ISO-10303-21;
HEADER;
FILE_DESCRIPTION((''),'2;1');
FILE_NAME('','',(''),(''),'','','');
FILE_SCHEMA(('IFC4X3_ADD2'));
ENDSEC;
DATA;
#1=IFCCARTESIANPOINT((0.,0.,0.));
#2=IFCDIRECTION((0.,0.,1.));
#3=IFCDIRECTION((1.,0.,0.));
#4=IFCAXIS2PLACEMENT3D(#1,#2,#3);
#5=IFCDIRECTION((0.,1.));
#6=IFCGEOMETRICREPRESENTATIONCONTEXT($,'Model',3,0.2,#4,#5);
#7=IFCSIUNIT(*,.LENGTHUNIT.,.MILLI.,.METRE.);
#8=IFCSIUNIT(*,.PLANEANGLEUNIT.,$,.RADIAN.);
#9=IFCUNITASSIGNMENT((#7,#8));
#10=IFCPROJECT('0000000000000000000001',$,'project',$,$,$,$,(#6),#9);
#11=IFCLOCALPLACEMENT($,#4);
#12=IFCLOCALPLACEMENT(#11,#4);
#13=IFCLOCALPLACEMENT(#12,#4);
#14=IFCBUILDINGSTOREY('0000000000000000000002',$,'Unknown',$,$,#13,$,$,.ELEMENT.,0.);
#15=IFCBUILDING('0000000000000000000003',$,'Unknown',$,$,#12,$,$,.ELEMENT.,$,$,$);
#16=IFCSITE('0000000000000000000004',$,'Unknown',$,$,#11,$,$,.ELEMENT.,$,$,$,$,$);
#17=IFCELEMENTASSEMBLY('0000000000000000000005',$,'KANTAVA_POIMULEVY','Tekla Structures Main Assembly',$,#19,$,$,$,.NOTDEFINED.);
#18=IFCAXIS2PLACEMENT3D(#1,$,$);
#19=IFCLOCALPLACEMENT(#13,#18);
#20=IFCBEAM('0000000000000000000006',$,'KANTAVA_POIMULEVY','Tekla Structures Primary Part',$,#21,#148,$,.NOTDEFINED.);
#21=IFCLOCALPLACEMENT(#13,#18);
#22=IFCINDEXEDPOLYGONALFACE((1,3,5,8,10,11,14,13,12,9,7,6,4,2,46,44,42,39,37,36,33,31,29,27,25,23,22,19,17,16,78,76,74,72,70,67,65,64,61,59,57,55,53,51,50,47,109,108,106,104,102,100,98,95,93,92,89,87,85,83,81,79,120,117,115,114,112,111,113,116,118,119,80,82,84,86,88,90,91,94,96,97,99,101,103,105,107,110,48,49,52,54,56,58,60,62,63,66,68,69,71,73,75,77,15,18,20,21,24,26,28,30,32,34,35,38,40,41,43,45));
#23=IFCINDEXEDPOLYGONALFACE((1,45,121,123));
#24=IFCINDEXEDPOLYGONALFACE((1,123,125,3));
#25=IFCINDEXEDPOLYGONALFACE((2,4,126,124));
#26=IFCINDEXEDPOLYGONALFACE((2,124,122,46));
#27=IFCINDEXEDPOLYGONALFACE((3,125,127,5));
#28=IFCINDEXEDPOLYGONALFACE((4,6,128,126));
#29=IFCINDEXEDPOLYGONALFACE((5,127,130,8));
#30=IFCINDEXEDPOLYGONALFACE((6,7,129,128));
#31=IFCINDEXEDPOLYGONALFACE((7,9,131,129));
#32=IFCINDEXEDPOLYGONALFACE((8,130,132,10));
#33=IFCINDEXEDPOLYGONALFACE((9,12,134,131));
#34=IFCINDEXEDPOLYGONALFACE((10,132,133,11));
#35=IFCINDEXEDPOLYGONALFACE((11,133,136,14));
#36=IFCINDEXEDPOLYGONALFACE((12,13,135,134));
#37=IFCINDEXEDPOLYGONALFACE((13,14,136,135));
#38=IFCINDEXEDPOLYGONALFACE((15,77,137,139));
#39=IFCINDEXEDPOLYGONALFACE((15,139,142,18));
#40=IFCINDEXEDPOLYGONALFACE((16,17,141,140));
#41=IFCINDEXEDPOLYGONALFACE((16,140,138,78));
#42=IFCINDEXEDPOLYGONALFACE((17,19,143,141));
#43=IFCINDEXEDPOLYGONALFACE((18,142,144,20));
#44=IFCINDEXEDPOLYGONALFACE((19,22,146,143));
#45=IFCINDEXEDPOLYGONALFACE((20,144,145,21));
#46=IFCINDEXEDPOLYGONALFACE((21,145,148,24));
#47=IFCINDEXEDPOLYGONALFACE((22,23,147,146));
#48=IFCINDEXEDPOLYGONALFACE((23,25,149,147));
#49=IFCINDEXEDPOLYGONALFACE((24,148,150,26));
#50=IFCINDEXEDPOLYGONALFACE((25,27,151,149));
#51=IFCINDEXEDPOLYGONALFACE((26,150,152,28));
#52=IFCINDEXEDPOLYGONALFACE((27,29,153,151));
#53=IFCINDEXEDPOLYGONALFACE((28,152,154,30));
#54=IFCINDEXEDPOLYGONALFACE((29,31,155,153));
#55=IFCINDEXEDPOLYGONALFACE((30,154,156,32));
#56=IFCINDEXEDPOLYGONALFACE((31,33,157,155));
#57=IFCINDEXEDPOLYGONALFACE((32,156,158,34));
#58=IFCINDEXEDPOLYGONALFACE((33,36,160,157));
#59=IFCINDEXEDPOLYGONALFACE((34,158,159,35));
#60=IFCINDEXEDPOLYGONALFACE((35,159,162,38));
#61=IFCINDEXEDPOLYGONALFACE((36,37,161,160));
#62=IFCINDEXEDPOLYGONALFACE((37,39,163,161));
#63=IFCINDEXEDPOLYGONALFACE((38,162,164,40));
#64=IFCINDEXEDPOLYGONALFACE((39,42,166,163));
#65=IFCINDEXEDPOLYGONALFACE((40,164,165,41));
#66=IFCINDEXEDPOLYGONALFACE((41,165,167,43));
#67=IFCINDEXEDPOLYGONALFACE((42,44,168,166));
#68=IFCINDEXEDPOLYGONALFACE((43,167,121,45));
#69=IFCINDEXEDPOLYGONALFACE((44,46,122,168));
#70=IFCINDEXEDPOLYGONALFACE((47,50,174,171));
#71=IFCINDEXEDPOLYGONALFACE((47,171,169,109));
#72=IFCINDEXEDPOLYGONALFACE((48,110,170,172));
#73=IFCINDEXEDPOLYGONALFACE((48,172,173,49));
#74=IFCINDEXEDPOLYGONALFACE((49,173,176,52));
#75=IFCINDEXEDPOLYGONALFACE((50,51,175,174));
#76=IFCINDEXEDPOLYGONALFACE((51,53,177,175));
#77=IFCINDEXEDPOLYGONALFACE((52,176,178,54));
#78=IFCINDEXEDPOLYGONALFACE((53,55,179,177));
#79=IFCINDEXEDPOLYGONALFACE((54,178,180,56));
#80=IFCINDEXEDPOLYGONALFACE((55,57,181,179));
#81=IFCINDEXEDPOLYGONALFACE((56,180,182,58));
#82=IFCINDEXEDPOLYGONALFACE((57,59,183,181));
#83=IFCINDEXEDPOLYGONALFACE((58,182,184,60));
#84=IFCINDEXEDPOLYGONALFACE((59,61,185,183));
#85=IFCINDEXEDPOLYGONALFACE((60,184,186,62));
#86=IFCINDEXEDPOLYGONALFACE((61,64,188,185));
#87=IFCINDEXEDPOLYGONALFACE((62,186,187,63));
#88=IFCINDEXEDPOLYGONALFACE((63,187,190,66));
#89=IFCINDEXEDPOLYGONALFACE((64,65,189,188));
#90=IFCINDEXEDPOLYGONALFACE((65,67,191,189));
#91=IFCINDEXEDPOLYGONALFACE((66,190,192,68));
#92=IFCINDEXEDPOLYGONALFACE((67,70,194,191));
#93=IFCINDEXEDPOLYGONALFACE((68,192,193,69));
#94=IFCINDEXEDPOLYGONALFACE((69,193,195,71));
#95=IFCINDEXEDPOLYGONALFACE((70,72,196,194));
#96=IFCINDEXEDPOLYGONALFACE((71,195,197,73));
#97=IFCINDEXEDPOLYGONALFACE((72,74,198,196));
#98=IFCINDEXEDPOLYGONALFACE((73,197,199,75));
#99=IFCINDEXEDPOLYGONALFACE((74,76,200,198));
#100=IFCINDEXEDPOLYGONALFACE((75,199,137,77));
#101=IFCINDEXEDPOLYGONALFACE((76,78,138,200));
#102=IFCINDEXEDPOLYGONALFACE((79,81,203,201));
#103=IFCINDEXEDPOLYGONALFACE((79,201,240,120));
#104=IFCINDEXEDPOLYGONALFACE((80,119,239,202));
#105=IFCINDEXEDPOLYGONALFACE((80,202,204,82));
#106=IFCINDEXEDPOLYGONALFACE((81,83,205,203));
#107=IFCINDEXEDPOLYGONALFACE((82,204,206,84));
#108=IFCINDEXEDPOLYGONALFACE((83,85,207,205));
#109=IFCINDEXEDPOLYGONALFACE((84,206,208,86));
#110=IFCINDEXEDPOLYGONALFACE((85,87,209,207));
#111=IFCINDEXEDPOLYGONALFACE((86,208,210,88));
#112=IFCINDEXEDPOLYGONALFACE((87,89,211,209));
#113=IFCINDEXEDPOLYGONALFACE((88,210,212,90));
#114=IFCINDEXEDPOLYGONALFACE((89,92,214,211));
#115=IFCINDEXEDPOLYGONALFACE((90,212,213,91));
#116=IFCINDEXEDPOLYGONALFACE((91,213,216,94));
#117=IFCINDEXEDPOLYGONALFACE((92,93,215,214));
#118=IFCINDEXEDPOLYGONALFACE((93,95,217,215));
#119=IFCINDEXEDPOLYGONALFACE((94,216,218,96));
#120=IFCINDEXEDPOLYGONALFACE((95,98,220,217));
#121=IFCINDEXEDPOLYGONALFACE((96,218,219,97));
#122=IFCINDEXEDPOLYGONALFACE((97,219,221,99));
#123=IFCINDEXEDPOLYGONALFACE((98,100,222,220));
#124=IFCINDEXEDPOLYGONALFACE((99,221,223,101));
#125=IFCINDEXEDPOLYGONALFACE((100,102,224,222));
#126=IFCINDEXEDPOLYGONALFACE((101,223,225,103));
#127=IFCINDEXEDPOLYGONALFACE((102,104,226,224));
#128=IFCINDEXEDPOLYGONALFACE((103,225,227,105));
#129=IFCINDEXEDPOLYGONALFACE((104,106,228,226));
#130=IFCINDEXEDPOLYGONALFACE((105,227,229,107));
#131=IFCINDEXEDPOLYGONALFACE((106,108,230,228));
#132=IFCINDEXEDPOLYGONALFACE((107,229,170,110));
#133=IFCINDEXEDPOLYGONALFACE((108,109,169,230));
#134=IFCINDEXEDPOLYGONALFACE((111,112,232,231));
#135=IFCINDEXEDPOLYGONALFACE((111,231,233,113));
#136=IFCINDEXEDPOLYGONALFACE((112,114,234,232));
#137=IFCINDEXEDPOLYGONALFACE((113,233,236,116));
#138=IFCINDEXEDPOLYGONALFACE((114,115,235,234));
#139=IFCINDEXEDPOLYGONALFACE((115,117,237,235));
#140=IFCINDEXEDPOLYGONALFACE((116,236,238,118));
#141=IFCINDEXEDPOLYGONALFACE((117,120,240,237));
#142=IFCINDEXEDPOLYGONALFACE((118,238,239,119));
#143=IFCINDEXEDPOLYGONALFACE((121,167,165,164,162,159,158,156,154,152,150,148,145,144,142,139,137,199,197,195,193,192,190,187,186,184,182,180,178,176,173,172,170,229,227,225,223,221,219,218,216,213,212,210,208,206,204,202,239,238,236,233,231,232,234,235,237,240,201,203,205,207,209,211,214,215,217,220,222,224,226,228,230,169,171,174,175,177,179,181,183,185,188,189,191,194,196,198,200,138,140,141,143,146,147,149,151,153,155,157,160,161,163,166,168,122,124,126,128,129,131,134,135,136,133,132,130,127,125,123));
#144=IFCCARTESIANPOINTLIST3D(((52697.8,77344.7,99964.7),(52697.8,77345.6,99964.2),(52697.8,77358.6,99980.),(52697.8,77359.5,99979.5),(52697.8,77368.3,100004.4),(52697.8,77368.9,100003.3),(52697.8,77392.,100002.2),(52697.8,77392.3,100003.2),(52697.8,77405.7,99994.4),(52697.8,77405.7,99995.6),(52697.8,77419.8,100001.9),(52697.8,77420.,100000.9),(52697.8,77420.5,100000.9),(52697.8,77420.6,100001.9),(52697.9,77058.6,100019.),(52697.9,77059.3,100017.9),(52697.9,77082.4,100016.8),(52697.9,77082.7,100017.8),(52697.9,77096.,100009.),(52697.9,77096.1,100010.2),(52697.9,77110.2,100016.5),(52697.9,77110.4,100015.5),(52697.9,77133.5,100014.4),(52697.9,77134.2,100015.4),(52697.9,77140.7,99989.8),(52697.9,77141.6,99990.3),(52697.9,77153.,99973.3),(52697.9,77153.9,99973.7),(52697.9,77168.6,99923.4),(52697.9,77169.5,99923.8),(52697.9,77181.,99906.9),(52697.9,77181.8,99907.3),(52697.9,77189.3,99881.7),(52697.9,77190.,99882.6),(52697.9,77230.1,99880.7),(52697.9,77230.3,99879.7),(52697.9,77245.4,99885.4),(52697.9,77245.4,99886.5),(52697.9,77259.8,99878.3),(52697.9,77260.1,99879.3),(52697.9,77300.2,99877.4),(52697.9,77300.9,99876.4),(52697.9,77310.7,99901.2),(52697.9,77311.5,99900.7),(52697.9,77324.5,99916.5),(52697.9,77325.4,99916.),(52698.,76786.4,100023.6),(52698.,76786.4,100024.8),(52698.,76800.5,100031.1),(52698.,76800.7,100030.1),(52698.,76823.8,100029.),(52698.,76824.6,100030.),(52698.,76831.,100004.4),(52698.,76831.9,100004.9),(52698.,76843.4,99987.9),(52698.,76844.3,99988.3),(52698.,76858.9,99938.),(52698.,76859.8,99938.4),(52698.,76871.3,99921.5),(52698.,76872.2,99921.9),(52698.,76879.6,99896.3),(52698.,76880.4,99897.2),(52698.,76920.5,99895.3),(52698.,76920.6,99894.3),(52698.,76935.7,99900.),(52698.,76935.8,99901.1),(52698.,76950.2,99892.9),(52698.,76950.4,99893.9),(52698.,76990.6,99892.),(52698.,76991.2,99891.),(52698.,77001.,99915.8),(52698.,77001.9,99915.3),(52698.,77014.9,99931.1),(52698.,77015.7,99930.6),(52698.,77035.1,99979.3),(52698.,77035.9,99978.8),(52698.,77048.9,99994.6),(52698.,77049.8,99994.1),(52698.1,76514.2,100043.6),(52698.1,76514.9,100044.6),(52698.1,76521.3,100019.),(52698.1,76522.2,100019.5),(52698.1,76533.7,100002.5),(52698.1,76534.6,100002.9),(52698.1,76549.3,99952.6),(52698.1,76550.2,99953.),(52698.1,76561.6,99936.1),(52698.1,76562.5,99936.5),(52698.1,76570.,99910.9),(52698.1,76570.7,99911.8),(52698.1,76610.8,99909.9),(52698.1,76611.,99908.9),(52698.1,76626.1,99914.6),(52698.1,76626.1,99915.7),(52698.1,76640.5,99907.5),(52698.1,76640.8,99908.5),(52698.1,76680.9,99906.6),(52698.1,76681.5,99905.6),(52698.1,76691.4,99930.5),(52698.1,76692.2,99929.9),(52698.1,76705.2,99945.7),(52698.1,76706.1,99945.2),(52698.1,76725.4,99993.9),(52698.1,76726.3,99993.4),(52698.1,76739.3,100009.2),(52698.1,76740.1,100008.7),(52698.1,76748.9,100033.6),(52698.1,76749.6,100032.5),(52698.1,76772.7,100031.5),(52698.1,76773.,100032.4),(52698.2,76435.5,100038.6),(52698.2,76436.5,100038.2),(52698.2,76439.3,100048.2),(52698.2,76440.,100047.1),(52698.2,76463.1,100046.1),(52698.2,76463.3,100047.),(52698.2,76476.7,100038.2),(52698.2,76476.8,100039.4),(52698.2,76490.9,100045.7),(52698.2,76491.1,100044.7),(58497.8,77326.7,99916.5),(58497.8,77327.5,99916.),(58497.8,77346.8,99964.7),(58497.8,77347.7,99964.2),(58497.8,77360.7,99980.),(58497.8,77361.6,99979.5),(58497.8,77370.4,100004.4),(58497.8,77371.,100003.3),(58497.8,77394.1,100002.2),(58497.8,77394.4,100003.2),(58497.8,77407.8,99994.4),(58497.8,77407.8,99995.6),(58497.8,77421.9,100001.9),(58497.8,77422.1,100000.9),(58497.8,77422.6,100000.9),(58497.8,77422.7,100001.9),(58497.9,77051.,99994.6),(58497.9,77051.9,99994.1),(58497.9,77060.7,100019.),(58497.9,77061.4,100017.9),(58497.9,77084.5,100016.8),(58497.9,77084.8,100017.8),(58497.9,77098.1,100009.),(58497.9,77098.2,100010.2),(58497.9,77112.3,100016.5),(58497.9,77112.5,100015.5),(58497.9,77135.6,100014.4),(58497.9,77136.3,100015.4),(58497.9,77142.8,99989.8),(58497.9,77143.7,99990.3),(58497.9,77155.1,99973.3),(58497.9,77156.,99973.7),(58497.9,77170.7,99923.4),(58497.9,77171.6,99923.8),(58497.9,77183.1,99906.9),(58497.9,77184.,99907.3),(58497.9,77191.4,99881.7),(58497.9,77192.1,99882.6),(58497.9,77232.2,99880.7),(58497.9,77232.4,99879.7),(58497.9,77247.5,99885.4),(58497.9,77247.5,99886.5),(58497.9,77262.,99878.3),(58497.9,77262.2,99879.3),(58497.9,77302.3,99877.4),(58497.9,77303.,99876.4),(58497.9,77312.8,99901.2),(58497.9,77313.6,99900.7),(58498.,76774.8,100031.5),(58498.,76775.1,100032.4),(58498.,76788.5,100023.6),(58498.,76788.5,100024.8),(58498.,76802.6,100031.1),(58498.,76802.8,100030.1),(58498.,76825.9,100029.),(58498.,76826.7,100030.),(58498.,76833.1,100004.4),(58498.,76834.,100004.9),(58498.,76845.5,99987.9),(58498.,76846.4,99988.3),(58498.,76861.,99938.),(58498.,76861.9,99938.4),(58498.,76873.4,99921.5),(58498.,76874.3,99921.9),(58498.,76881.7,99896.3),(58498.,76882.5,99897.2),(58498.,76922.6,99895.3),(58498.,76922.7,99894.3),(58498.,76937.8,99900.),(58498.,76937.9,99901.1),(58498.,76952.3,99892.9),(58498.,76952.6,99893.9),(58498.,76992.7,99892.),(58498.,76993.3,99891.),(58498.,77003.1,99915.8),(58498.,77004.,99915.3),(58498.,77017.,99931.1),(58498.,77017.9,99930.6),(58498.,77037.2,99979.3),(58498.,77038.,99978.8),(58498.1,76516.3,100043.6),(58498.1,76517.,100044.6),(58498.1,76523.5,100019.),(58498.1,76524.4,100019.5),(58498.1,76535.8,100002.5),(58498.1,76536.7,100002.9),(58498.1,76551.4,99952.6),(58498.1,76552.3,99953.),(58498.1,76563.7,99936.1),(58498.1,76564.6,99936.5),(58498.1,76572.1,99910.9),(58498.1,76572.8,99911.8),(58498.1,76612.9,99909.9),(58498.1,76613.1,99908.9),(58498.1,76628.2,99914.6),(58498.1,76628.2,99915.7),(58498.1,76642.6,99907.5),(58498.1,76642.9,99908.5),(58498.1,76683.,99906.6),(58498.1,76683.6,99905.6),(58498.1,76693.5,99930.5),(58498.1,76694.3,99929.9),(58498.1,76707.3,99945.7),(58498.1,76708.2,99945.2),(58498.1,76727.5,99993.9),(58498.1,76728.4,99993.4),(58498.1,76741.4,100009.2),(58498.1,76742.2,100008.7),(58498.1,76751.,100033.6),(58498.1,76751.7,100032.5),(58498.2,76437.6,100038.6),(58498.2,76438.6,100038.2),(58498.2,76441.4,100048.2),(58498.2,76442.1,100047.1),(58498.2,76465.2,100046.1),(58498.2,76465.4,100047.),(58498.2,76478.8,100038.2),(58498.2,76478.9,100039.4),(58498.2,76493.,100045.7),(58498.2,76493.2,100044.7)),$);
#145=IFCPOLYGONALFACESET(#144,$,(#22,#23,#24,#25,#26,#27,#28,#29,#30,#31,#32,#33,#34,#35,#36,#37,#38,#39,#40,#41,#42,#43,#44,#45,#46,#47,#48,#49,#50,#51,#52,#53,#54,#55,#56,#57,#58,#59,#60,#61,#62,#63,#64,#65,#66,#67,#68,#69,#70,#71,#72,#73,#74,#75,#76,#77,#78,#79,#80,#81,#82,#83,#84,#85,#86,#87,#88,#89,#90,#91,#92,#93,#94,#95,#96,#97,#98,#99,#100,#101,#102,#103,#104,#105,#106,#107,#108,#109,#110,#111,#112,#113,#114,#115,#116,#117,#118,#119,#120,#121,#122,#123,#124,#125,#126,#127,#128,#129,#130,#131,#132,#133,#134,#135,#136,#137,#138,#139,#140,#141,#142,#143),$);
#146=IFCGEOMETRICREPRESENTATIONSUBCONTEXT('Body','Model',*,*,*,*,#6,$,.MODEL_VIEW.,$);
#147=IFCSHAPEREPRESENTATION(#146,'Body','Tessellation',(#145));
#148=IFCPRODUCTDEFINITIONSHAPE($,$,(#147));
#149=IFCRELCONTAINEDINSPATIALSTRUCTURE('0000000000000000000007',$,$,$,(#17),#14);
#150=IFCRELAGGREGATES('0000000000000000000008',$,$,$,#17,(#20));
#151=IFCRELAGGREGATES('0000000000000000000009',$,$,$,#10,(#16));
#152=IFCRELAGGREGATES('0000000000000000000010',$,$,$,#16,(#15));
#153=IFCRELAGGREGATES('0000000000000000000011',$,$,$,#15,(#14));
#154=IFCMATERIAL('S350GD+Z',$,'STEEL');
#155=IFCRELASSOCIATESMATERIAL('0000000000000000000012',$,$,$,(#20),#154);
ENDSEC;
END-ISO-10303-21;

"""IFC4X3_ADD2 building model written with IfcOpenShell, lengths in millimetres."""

from ifc_helpers import new_model, si_unit, direction, frame, origin_with_axes, place, context, subcontext, project, spatial, line, indexed_curve, outline, extrude, material, element, aggregate, save


model = new_model("IFC4X3_ADD2")

# Units and contexts
model_context = context("Model", 3, precision=0.2, world=origin_with_axes(), true_north=direction((0.0, 1.0)))
body_context = subcontext(model_context, "Body", "Model", "MODEL_VIEW")
ifc_project = project(units=[si_unit("LENGTHUNIT", "METRE", prefix="MILLI"), si_unit("PLANEANGLEUNIT", "RADIAN")], contexts=[model_context])

# Site, building, storey
site_placement = place(None, origin_with_axes())
site = spatial("IfcSite", under=ifc_project, at=site_placement, Name="Unknown", CompositionType="ELEMENT")
building_placement = place(site_placement, origin_with_axes())
building = spatial("IfcBuilding", under=site, at=building_placement, Name="Unknown", CompositionType="ELEMENT")
storey_placement = place(building_placement, origin_with_axes())
storey = spatial("IfcBuildingStorey", under=building, at=storey_placement, Name="Unknown", CompositionType="ELEMENT", Elevation=0.0)

# Element assembly, beam
ifc_material_1 = material(Name="S350GD+Z", Category="STEEL")
assembly_1_placement = place(storey_placement, frame((58498.0, 76940.6, 99959.1), z_axis=(-0.000363, 0.99889, -0.047106), x_axis=(-1.0, -0.000363, 0.0)))
assembly_1 = element("IfcElementAssembly", 1, at=assembly_1_placement, inside=storey, Name="KANTAVA_POIMULEVY", Description="Tekla Structures Main Assembly", PredefinedType="NOTDEFINED")
beam_1_placement = place(assembly_1_placement, origin_with_axes())
beam_1 = element("IfcBeam", 2, at=beam_1_placement, material=ifc_material_1, Name="KANTAVA_POIMULEVY", Description="Tekla Structures Primary Part", PredefinedType="NOTDEFINED", context=body_context, shape_type="SolidModel", body=[
    extrude(outline(indexed_curve([(479.5, 65.5), (478.8, 65.5), (465.0, 58.5), (451.2, 65.5), (427.1, 65.5), (418.6, 40.7), (405.5, 24.8), (387.6, -24.3), (374.5, -40.2), (365.1, -64.5), (325.0, -64.5), (310.0, -58.1), (295.0, -64.5), (254.8, -64.5), (245.5, -40.2), (232.4, -24.3), (214.5, 24.8), (201.4, 40.7), (192.9, 65.5), (168.8, 65.5), (155.0, 58.5), (141.2, 65.5), (117.1, 65.5), (108.6, 40.7), (95.5, 24.8), (77.6, -24.3), (64.5, -40.2), (55.1, -64.5), (15.0, -64.5), (0.0, -58.1), (-15.0, -64.5), (-55.2, -64.5), (-64.5, -40.2), (-77.6, -24.3), (-95.5, 24.8), (-108.6, 40.7), (-117.2, 65.5), (-141.2, 65.5), (-155.0, 58.5), (-168.8, 65.5), (-192.9, 65.5), (-201.4, 40.7), (-214.5, 24.8), (-232.4, -24.3), (-245.5, -40.2), (-254.9, -64.5), (-295.0, -64.5), (-310.0, -58.1), (-325.0, -64.5), (-365.2, -64.5), (-374.5, -40.2), (-387.6, -24.3), (-405.5, 24.8), (-418.6, 40.7), (-427.1, 65.5), (-451.2, 65.5), (-465.0, 58.5), (-478.8, 65.5), (-502.9, 65.5), (-506.2, 55.7), (-505.2, 55.4), (-502.1, 64.5), (-479.0, 64.5), (-465.0, 57.3), (-451.0, 64.5), (-427.9, 64.5), (-419.5, 40.2), (-406.4, 24.3), (-388.5, -24.8), (-375.4, -40.7), (-365.9, -65.5), (-324.8, -65.5), (-310.0, -59.1), (-295.2, -65.5), (-254.2, -65.5), (-244.6, -40.7), (-231.5, -24.8), (-213.6, 24.3), (-200.5, 40.2), (-192.1, 64.5), (-169.0, 64.5), (-155.0, 57.3), (-141.0, 64.5), (-117.9, 64.5), (-109.5, 40.2), (-96.4, 24.3), (-78.5, -24.8), (-65.4, -40.7), (-55.9, -65.5), (-14.8, -65.5), (0.0, -59.1), (14.8, -65.5), (55.8, -65.5), (65.4, -40.7), (78.5, -24.8), (96.4, 24.3), (109.5, 40.2), (117.8, 64.5), (141.0, 64.5), (155.0, 57.3), (169.0, 64.5), (192.1, 64.5), (200.5, 40.2), (213.6, 24.3), (231.5, -24.8), (244.6, -40.7), (254.1, -65.5), (295.2, -65.5), (310.0, -59.1), (324.8, -65.5), (365.8, -65.5), (375.4, -40.7), (388.5, -24.8), (406.4, 24.3), (419.5, 40.2), (427.9, 64.5), (451.0, 64.5), (465.0, 57.3), (479.0, 64.5), (479.5, 64.5)], segments=[line(1, 2, 3, 4, 5, 6, 7, 8, 9, 10, 11, 12, 13, 14, 15, 16, 17, 18, 19, 20, 21, 22, 23, 24, 25, 26, 27, 28, 29, 30, 31, 32, 33, 34, 35, 36, 37, 38, 39, 40, 41, 42, 43, 44, 45, 46, 47, 48, 49, 50, 51, 52, 53, 54, 55, 56, 57, 58, 59, 60, 61, 62, 63, 64, 65, 66, 67, 68, 69, 70, 71, 72, 73, 74, 75, 76, 77, 78, 79, 80, 81, 82, 83, 84, 85, 86, 87, 88, 89, 90, 91, 92, 93, 94, 95, 96, 97, 98, 99, 100, 101, 102, 103, 104, 105, 106, 107, 108, 109, 110, 111, 112, 113, 114, 115, 116, 117, 118, 119, 120, 1)])), frame((0.0, 0.0, 0.0), z_axis=(-1.0, 0.0, 0.0), x_axis=(0.0, 0.0, 1.0)), (0.0, 0.0, -1.0), 5800.0),
])
aggregate(assembly_1, [beam_1])

save(model, "model.ifc")
